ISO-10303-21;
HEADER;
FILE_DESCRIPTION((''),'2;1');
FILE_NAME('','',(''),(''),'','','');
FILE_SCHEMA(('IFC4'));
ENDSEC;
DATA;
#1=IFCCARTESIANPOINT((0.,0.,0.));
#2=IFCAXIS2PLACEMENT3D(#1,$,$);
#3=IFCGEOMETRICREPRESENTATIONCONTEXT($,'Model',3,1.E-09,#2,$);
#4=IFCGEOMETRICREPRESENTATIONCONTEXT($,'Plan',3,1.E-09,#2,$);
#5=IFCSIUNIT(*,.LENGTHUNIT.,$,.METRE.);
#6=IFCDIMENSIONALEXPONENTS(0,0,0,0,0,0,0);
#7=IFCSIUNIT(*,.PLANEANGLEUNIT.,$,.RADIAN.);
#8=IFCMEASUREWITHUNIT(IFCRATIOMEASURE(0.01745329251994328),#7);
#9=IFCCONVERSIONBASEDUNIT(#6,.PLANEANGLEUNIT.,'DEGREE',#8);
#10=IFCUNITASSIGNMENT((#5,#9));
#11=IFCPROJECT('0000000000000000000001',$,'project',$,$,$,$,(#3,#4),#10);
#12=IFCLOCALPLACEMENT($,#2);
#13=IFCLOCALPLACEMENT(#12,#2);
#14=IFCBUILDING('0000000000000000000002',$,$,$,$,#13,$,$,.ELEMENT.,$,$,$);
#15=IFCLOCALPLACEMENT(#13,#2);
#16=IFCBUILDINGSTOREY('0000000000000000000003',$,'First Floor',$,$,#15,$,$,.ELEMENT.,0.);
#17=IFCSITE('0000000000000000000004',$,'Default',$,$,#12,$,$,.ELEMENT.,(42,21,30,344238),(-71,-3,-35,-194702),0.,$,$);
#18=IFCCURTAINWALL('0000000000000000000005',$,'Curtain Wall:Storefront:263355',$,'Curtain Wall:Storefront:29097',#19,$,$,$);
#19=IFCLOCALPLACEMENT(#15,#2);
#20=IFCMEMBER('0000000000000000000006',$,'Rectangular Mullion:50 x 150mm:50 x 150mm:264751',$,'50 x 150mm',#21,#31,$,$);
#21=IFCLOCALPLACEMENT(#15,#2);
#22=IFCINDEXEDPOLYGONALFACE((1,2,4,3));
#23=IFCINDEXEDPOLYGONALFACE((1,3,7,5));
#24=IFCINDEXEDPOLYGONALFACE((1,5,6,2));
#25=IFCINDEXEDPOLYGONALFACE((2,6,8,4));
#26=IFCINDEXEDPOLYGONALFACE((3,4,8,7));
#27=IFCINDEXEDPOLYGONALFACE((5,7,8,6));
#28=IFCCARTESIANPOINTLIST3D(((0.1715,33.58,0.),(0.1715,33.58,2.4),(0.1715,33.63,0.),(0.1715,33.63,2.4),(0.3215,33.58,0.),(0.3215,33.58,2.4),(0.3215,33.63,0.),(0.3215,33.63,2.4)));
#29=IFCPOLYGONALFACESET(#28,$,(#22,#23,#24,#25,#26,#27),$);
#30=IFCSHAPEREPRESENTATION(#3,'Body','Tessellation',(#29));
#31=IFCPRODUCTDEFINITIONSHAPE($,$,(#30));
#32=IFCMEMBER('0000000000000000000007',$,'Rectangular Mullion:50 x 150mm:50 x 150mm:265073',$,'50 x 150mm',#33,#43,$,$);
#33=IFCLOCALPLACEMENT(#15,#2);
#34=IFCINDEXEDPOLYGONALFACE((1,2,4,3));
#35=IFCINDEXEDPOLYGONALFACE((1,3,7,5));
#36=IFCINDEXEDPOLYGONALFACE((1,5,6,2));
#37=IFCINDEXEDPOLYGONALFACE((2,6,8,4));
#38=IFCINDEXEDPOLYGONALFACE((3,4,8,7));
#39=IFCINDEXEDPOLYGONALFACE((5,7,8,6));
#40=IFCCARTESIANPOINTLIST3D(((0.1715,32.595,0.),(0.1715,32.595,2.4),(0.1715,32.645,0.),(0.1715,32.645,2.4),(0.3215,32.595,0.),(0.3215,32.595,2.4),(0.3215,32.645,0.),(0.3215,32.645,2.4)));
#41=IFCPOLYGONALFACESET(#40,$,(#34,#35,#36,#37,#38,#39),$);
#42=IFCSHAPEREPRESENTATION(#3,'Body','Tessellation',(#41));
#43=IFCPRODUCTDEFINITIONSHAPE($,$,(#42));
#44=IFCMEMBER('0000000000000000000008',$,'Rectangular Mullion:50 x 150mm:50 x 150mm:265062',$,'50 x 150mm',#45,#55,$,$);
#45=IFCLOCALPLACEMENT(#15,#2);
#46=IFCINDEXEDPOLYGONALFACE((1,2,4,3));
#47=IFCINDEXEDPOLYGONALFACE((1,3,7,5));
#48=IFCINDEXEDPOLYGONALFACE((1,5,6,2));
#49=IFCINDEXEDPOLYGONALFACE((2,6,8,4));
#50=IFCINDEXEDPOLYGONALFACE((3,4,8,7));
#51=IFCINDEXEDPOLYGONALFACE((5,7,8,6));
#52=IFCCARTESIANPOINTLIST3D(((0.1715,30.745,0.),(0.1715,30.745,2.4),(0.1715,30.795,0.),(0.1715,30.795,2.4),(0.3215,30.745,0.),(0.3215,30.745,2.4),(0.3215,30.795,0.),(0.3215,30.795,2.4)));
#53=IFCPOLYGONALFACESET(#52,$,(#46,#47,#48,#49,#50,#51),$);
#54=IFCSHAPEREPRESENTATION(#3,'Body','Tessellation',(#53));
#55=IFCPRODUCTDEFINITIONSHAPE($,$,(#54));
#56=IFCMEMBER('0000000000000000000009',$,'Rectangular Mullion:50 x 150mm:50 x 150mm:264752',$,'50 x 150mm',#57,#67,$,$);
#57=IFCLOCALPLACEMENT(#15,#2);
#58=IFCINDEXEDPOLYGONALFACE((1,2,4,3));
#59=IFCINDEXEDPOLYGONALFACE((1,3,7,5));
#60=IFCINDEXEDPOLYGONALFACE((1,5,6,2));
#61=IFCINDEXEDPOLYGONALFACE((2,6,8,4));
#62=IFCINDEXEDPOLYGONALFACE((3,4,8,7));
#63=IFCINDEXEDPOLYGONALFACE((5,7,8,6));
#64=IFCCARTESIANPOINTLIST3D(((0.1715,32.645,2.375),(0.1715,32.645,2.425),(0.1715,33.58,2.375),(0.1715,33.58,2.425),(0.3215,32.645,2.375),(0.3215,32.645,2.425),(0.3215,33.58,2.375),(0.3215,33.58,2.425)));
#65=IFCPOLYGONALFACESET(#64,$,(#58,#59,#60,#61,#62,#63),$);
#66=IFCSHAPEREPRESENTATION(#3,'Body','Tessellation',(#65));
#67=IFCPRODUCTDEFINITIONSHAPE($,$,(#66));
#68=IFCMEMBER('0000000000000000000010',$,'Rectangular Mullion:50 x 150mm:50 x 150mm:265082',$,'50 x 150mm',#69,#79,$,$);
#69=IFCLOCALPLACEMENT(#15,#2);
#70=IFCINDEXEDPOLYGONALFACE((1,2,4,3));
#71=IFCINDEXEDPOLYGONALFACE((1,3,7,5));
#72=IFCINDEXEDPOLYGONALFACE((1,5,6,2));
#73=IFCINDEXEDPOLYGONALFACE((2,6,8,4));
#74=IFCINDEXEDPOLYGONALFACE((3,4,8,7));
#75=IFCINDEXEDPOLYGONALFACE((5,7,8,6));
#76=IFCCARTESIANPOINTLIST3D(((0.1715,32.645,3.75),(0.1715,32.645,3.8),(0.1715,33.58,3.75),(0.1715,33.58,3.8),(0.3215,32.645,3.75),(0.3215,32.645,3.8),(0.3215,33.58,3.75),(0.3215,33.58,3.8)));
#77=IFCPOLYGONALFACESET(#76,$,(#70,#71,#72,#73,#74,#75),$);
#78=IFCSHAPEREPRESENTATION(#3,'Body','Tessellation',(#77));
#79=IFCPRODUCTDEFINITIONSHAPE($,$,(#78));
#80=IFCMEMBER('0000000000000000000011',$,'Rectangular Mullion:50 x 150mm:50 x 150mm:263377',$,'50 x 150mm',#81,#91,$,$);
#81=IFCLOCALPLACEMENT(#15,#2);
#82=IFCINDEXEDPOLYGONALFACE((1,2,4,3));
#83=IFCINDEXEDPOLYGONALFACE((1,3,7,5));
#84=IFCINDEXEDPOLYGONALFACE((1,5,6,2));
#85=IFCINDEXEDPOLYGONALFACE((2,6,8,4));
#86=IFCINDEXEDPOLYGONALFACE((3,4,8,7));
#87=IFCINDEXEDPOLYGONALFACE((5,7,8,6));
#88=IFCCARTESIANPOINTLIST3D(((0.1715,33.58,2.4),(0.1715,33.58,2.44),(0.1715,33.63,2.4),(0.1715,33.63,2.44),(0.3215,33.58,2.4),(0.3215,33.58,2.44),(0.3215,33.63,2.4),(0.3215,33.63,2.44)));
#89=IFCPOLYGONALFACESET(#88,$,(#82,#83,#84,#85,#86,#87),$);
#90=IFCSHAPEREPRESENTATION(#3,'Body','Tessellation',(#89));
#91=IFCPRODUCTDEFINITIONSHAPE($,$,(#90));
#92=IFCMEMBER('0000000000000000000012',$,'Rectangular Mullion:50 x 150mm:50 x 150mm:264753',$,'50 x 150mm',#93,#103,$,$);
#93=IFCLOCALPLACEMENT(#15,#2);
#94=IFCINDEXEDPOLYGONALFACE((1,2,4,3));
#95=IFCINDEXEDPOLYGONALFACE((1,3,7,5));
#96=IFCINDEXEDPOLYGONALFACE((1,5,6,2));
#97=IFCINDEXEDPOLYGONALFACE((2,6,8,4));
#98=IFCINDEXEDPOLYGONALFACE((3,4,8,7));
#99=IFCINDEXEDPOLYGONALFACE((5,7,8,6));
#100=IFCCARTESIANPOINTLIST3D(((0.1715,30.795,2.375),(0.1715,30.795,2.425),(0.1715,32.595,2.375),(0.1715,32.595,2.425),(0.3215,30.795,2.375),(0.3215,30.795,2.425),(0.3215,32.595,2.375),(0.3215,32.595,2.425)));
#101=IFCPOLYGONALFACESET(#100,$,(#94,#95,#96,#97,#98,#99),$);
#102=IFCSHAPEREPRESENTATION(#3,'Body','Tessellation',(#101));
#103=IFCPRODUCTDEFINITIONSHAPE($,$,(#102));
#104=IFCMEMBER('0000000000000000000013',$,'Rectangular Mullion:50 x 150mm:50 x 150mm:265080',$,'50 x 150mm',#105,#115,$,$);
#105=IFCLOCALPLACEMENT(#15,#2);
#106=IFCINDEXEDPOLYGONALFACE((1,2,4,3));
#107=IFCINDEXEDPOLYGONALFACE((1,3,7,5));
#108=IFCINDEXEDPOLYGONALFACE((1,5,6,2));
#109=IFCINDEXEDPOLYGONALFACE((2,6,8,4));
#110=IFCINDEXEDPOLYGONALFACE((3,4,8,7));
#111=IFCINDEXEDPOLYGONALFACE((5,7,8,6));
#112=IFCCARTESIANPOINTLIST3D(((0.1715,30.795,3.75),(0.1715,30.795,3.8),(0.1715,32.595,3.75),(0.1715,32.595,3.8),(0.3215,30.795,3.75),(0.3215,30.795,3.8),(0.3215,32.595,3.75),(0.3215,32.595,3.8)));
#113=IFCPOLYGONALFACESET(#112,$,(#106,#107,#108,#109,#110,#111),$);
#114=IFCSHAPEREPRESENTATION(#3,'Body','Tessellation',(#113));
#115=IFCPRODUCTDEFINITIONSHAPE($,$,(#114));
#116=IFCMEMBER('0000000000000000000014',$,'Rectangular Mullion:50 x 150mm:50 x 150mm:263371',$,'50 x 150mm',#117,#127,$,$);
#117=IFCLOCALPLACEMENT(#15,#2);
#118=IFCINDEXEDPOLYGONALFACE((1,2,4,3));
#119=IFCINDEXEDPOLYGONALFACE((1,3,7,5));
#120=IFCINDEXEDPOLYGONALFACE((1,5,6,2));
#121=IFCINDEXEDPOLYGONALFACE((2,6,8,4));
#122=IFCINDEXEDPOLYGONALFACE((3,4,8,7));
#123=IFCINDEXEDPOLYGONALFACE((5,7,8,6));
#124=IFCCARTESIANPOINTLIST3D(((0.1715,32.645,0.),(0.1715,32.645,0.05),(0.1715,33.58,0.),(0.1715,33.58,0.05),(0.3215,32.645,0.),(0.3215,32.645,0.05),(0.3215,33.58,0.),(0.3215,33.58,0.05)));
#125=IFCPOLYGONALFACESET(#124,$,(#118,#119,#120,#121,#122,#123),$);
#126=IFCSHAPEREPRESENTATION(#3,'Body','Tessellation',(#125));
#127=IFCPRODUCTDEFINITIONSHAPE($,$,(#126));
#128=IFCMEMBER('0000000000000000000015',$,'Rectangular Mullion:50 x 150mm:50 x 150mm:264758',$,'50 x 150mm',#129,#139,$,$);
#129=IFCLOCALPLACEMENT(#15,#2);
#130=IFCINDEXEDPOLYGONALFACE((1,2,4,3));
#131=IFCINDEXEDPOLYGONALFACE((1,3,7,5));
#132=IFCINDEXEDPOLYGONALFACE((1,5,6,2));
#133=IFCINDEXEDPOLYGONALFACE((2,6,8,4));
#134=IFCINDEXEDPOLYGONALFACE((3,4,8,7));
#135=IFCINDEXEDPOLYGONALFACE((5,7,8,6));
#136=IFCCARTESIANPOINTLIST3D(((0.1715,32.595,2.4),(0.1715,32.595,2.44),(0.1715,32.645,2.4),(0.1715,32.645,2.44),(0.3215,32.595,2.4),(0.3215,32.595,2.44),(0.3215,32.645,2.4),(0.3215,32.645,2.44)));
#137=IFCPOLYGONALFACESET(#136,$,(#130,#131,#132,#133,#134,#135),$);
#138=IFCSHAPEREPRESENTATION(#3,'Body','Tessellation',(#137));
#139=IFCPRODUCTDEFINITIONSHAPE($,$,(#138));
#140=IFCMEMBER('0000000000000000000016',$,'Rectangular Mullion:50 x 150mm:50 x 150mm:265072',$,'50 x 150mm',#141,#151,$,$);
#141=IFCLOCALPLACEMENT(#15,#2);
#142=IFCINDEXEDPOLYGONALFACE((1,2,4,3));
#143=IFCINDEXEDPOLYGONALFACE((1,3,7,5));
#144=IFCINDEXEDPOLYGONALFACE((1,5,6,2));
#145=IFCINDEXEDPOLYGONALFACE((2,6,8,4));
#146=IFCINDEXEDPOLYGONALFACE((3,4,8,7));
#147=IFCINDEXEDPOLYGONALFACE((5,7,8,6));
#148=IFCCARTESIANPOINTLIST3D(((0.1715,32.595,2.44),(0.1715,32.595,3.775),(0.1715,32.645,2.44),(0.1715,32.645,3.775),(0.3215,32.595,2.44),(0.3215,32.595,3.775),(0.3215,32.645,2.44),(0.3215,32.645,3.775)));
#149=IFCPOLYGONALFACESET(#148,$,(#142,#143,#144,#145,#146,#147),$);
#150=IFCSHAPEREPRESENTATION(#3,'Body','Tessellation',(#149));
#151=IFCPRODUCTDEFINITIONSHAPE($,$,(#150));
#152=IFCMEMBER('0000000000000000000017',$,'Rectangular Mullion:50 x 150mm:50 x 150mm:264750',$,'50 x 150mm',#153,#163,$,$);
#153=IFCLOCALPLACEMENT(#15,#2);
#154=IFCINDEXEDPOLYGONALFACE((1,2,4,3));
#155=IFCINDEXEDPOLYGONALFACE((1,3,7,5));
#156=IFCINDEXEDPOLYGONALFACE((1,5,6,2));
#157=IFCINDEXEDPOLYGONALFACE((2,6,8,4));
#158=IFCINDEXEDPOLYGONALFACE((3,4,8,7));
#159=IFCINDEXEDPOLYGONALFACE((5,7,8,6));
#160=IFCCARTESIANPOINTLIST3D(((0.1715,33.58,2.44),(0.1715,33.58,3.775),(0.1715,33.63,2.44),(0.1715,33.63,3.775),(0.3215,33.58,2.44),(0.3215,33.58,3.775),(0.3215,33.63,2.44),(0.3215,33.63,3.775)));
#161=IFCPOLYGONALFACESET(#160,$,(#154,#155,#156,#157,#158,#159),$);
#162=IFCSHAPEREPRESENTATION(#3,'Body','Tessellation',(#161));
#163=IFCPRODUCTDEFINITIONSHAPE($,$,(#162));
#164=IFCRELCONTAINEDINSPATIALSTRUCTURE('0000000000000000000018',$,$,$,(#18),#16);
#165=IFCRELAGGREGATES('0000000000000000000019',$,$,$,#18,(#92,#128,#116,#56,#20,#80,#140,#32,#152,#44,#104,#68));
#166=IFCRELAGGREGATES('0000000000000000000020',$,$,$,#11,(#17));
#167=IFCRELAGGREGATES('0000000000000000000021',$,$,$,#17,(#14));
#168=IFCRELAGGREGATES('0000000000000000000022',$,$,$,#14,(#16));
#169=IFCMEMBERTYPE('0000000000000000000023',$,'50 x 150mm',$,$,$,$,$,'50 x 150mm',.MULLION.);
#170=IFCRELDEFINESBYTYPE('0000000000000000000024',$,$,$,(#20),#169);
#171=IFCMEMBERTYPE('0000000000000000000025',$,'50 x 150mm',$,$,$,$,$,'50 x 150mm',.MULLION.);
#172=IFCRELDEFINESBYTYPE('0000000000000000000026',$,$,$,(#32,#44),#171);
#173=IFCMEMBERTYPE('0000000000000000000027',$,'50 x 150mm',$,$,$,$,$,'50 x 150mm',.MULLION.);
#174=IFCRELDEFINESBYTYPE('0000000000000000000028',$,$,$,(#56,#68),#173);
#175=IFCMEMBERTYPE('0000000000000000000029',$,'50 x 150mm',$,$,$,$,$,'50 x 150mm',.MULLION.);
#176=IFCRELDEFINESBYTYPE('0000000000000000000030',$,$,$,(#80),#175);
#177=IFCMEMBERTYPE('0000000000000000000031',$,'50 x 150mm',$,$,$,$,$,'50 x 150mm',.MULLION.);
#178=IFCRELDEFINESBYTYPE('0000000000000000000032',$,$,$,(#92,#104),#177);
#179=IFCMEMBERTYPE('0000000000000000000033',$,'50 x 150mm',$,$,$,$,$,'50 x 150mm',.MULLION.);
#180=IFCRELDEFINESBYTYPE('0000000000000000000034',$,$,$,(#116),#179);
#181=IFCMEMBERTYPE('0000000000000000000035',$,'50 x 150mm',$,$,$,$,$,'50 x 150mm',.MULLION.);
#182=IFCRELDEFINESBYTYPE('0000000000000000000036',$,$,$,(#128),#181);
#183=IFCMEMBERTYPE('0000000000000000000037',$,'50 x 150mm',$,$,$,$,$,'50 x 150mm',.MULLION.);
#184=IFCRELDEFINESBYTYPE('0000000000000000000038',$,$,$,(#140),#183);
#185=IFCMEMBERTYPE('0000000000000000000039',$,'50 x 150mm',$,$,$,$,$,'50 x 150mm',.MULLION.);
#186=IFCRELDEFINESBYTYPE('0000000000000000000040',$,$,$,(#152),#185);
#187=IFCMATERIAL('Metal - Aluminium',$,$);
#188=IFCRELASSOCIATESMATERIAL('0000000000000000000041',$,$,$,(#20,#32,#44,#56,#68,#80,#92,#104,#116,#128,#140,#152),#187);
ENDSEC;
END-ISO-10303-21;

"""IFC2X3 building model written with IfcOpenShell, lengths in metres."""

from ifc_helpers import new_model, entity, si_unit, converted_unit, frame, origin, origin_2d_with_axis, place, context, project, spatial, rectangle, extrude, source, transform, mapped, material, type_object, type_shapes, element, aggregate, save


model = new_model("IFC2X3")

# Units and contexts
model_context = context("Model", 3, precision=1e-09, world=origin())
plan_context = context("Plan", 3, precision=1e-09, world=origin())
ifc_project = project(units=[si_unit("LENGTHUNIT", "METRE"), converted_unit("PLANEANGLEUNIT", "DEGREE", entity("IfcRatioMeasure", 0.01745329251994328), si_unit("PLANEANGLEUNIT", "RADIAN"), dimensions=[0, 0, 0, 0, 0, 0, 0])], contexts=[model_context, plan_context])

# Site, building, storey
site_placement = place(None, origin())
site = spatial("IfcSite", under=ifc_project, at=site_placement, Name="Default", CompositionType="ELEMENT", RefLatitude=(42, 21, 30, 344238), RefLongitude=(-71, -3, -35, -194702), RefElevation=0.0)
building_placement = place(site_placement, origin())
building = spatial("IfcBuilding", under=site, at=building_placement, CompositionType="ELEMENT")
storey_placement = place(building_placement, origin())
storey = spatial("IfcBuildingStorey", under=building, at=storey_placement, Name="First Floor", CompositionType="ELEMENT", Elevation=0.0)

# Curtain wall, members
curtain_wall_placement = place(storey_placement, origin())
curtain_wall = element("IfcCurtainWall", 1, at=curtain_wall_placement, inside=storey, Name="Curtain Wall:Storefront:263355", ObjectType="Curtain Wall:Storefront:29097")
ifc_material_1 = material(Name="Metal - Aluminium")
member_type_1 = type_object("IfcMemberType", Name="50 x 150mm", ElementType="50 x 150mm", PredefinedType="MULLION")
shared_shape_1 = source(origin(), model_context, "Body", "SweptSolid", [
    extrude(rectangle(XDim=0.05, YDim=0.15, at=origin_2d_with_axis()), frame((-0.025, 0.0, -2.4), z_axis=(0.0, 0.0, 1.0), x_axis=(-1.0, 0.0, 0.0)), (0.0, 0.0, 1.0), 2.4),
])
type_shapes(member_type_1, [shared_shape_1])
member_1_placement = place(storey_placement, frame((0.2465, 33.63, 2.4), z_axis=(0.0, 0.0, 1.0), x_axis=(0.0, 1.0, 0.0)))
member_1 = element("IfcMember", 2, at=member_1_placement, type_object=member_type_1, material=ifc_material_1, Name="Rectangular Mullion:50 x 150mm:50 x 150mm:264751", ObjectType="50 x 150mm", context=model_context, shape_type="MappedRepresentation", body=[
    mapped(shared_shape_1, transform((0.0, 0.0, 0.0), scale=1.0)),
])
member_type_2 = type_object("IfcMemberType", Name="50 x 150mm", ElementType="50 x 150mm", PredefinedType="MULLION")
shared_shape_2 = source(origin(), model_context, "Body", "SweptSolid", [
    extrude(rectangle(XDim=0.05, YDim=0.15, at=origin_2d_with_axis()), frame((0.0, 0.0, -2.4), z_axis=(0.0, 0.0, 1.0), x_axis=(-1.0, 0.0, 0.0)), (0.0, 0.0, 1.0), 2.4),
])
type_shapes(member_type_2, [shared_shape_2])
member_2_placement = place(storey_placement, frame((0.2465, 32.62, 0.0), z_axis=(0.0, 0.0, -1.0), x_axis=(0.0, -1.0, 0.0)))
member_2 = element("IfcMember", 3, at=member_2_placement, type_object=member_type_2, material=ifc_material_1, Name="Rectangular Mullion:50 x 150mm:50 x 150mm:265073", ObjectType="50 x 150mm", context=model_context, shape_type="MappedRepresentation", body=[
    mapped(shared_shape_2, transform((0.0, 0.0, 0.0), scale=1.0)),
])
member_3_placement = place(storey_placement, frame((0.2465, 30.77, 0.0), z_axis=(0.0, 0.0, -1.0), x_axis=(0.0, -1.0, 0.0)))
member_3 = element("IfcMember", 4, at=member_3_placement, type_object=member_type_2, material=ifc_material_1, Name="Rectangular Mullion:50 x 150mm:50 x 150mm:265062", ObjectType="50 x 150mm", context=model_context, shape_type="MappedRepresentation", body=[
    mapped(shared_shape_2, transform((0.0, 0.0, 0.0), scale=1.0)),
])
member_type_3 = type_object("IfcMemberType", Name="50 x 150mm", ElementType="50 x 150mm", PredefinedType="MULLION")
shared_shape_3 = source(origin(), model_context, "Body", "SweptSolid", [
    extrude(rectangle(XDim=0.05, YDim=0.15, at=origin_2d_with_axis()), frame((0.0, 0.0, -0.935), z_axis=(0.0, 0.0, 1.0), x_axis=(-1.0, 0.0, 0.0)), (0.0, 0.0, 1.0), 0.935),
])
type_shapes(member_type_3, [shared_shape_3])
member_4_placement = place(storey_placement, frame((0.2465, 32.645, 2.4), z_axis=(0.0, -1.0, 0.0), x_axis=(0.0, 0.0, 1.0)))
member_4 = element("IfcMember", 5, at=member_4_placement, type_object=member_type_3, material=ifc_material_1, Name="Rectangular Mullion:50 x 150mm:50 x 150mm:264752", ObjectType="50 x 150mm", context=model_context, shape_type="MappedRepresentation", body=[
    mapped(shared_shape_3, transform((0.0, 0.0, 0.0), scale=1.0)),
])
member_5_placement = place(storey_placement, frame((0.2465, 32.645, 3.775), z_axis=(0.0, -1.0, 0.0), x_axis=(0.0, 0.0, 1.0)))
member_5 = element("IfcMember", 6, at=member_5_placement, type_object=member_type_3, material=ifc_material_1, Name="Rectangular Mullion:50 x 150mm:50 x 150mm:265082", ObjectType="50 x 150mm", context=model_context, shape_type="MappedRepresentation", body=[
    mapped(shared_shape_3, transform((0.0, 0.0, 0.0), scale=1.0)),
])
member_type_4 = type_object("IfcMemberType", Name="50 x 150mm", ElementType="50 x 150mm", PredefinedType="MULLION")
shared_shape_4 = source(origin(), model_context, "Body", "SweptSolid", [
    extrude(rectangle(XDim=0.05, YDim=0.15, at=origin_2d_with_axis()), frame((-0.025, 0.0, -0.04), z_axis=(0.0, 0.0, 1.0), x_axis=(-1.0, 0.0, 0.0)), (0.0, 0.0, 1.0), 0.04),
])
type_shapes(member_type_4, [shared_shape_4])
member_6_placement = place(storey_placement, frame((0.2465, 33.63, 2.44), z_axis=(0.0, 0.0, 1.0), x_axis=(0.0, 1.0, 0.0)))
member_6 = element("IfcMember", 7, at=member_6_placement, type_object=member_type_4, material=ifc_material_1, Name="Rectangular Mullion:50 x 150mm:50 x 150mm:263377", ObjectType="50 x 150mm", context=model_context, shape_type="MappedRepresentation", body=[
    mapped(shared_shape_4, transform((0.0, 0.0, 0.0), scale=1.0)),
])
member_type_5 = type_object("IfcMemberType", Name="50 x 150mm", ElementType="50 x 150mm", PredefinedType="MULLION")
shared_shape_5 = source(origin(), model_context, "Body", "SweptSolid", [
    extrude(rectangle(XDim=0.05, YDim=0.15, at=origin_2d_with_axis()), frame((0.0, 0.0, -1.8), z_axis=(0.0, 0.0, 1.0), x_axis=(-1.0, 0.0, 0.0)), (0.0, 0.0, 1.0), 1.8),
])
type_shapes(member_type_5, [shared_shape_5])
member_7_placement = place(storey_placement, frame((0.2465, 30.795, 2.4), z_axis=(0.0, -1.0, 0.0), x_axis=(0.0, 0.0, 1.0)))
member_7 = element("IfcMember", 8, at=member_7_placement, type_object=member_type_5, material=ifc_material_1, Name="Rectangular Mullion:50 x 150mm:50 x 150mm:264753", ObjectType="50 x 150mm", context=model_context, shape_type="MappedRepresentation", body=[
    mapped(shared_shape_5, transform((0.0, 0.0, 0.0), scale=1.0)),
])
member_8_placement = place(storey_placement, frame((0.2465, 30.795, 3.775), z_axis=(0.0, -1.0, 0.0), x_axis=(0.0, 0.0, 1.0)))
member_8 = element("IfcMember", 9, at=member_8_placement, type_object=member_type_5, material=ifc_material_1, Name="Rectangular Mullion:50 x 150mm:50 x 150mm:265080", ObjectType="50 x 150mm", context=model_context, shape_type="MappedRepresentation", body=[
    mapped(shared_shape_5, transform((0.0, 0.0, 0.0), scale=1.0)),
])
member_type_6 = type_object("IfcMemberType", Name="50 x 150mm", ElementType="50 x 150mm", PredefinedType="MULLION")
shared_shape_6 = source(origin(), model_context, "Body", "SweptSolid", [
    extrude(rectangle(XDim=0.05, YDim=0.15, at=origin_2d_with_axis()), frame((-0.025, 0.0, -0.935), z_axis=(0.0, 0.0, 1.0), x_axis=(-1.0, 0.0, 0.0)), (0.0, 0.0, 1.0), 0.935),
])
type_shapes(member_type_6, [shared_shape_6])
member_9_placement = place(storey_placement, frame((0.2465, 33.58, 0.0), z_axis=(0.0, 1.0, 0.0), x_axis=(0.0, 0.0, -1.0)))
member_9 = element("IfcMember", 10, at=member_9_placement, type_object=member_type_6, material=ifc_material_1, Name="Rectangular Mullion:50 x 150mm:50 x 150mm:263371", ObjectType="50 x 150mm", context=model_context, shape_type="MappedRepresentation", body=[
    mapped(shared_shape_6, transform((0.0, 0.0, 0.0), scale=1.0)),
])
member_type_7 = type_object("IfcMemberType", Name="50 x 150mm", ElementType="50 x 150mm", PredefinedType="MULLION")
shared_shape_7 = source(origin(), model_context, "Body", "SweptSolid", [
    extrude(rectangle(XDim=0.05, YDim=0.15, at=origin_2d_with_axis()), frame((0.0, 0.0, -0.04), z_axis=(0.0, 0.0, 1.0), x_axis=(-1.0, 0.0, 0.0)), (0.0, 0.0, 1.0), 0.04),
])
type_shapes(member_type_7, [shared_shape_7])
member_10_placement = place(storey_placement, frame((0.2465, 32.62, 2.4), z_axis=(0.0, 0.0, -1.0), x_axis=(0.0, -1.0, 0.0)))
member_10 = element("IfcMember", 11, at=member_10_placement, type_object=member_type_7, material=ifc_material_1, Name="Rectangular Mullion:50 x 150mm:50 x 150mm:264758", ObjectType="50 x 150mm", context=model_context, shape_type="MappedRepresentation", body=[
    mapped(shared_shape_7, transform((0.0, 0.0, 0.0), scale=1.0)),
])
member_type_8 = type_object("IfcMemberType", Name="50 x 150mm", ElementType="50 x 150mm", PredefinedType="MULLION")
shared_shape_8 = source(origin(), model_context, "Body", "SweptSolid", [
    extrude(rectangle(XDim=0.05, YDim=0.15, at=origin_2d_with_axis()), frame((0.0, 0.0, -1.335), z_axis=(0.0, 0.0, 1.0), x_axis=(-1.0, 0.0, 0.0)), (0.0, 0.0, 1.0), 1.335),
])
type_shapes(member_type_8, [shared_shape_8])
member_11_placement = place(storey_placement, frame((0.2465, 32.62, 2.44), z_axis=(0.0, 0.0, -1.0), x_axis=(0.0, -1.0, 0.0)))
member_11 = element("IfcMember", 12, at=member_11_placement, type_object=member_type_8, material=ifc_material_1, Name="Rectangular Mullion:50 x 150mm:50 x 150mm:265072", ObjectType="50 x 150mm", context=model_context, shape_type="MappedRepresentation", body=[
    mapped(shared_shape_8, transform((0.0, 0.0, 0.0), scale=1.0)),
])
member_type_9 = type_object("IfcMemberType", Name="50 x 150mm", ElementType="50 x 150mm", PredefinedType="MULLION")
shared_shape_9 = source(origin(), model_context, "Body", "SweptSolid", [
    extrude(rectangle(XDim=0.05, YDim=0.15, at=origin_2d_with_axis()), frame((-0.025, 0.0, -1.335), z_axis=(0.0, 0.0, 1.0), x_axis=(-1.0, 0.0, 0.0)), (0.0, 0.0, 1.0), 1.335),
])
type_shapes(member_type_9, [shared_shape_9])
member_12_placement = place(storey_placement, frame((0.2465, 33.63, 3.775), z_axis=(0.0, 0.0, 1.0), x_axis=(0.0, 1.0, 0.0)))
member_12 = element("IfcMember", 13, at=member_12_placement, type_object=member_type_9, material=ifc_material_1, Name="Rectangular Mullion:50 x 150mm:50 x 150mm:264750", ObjectType="50 x 150mm", context=model_context, shape_type="MappedRepresentation", body=[
    mapped(shared_shape_9, transform((0.0, 0.0, 0.0), scale=1.0)),
])
aggregate(curtain_wall, [member_7, member_10, member_9, member_4, member_1, member_6, member_11, member_2, member_12, member_3, member_8, member_5])

save(model, "model.ifc")
